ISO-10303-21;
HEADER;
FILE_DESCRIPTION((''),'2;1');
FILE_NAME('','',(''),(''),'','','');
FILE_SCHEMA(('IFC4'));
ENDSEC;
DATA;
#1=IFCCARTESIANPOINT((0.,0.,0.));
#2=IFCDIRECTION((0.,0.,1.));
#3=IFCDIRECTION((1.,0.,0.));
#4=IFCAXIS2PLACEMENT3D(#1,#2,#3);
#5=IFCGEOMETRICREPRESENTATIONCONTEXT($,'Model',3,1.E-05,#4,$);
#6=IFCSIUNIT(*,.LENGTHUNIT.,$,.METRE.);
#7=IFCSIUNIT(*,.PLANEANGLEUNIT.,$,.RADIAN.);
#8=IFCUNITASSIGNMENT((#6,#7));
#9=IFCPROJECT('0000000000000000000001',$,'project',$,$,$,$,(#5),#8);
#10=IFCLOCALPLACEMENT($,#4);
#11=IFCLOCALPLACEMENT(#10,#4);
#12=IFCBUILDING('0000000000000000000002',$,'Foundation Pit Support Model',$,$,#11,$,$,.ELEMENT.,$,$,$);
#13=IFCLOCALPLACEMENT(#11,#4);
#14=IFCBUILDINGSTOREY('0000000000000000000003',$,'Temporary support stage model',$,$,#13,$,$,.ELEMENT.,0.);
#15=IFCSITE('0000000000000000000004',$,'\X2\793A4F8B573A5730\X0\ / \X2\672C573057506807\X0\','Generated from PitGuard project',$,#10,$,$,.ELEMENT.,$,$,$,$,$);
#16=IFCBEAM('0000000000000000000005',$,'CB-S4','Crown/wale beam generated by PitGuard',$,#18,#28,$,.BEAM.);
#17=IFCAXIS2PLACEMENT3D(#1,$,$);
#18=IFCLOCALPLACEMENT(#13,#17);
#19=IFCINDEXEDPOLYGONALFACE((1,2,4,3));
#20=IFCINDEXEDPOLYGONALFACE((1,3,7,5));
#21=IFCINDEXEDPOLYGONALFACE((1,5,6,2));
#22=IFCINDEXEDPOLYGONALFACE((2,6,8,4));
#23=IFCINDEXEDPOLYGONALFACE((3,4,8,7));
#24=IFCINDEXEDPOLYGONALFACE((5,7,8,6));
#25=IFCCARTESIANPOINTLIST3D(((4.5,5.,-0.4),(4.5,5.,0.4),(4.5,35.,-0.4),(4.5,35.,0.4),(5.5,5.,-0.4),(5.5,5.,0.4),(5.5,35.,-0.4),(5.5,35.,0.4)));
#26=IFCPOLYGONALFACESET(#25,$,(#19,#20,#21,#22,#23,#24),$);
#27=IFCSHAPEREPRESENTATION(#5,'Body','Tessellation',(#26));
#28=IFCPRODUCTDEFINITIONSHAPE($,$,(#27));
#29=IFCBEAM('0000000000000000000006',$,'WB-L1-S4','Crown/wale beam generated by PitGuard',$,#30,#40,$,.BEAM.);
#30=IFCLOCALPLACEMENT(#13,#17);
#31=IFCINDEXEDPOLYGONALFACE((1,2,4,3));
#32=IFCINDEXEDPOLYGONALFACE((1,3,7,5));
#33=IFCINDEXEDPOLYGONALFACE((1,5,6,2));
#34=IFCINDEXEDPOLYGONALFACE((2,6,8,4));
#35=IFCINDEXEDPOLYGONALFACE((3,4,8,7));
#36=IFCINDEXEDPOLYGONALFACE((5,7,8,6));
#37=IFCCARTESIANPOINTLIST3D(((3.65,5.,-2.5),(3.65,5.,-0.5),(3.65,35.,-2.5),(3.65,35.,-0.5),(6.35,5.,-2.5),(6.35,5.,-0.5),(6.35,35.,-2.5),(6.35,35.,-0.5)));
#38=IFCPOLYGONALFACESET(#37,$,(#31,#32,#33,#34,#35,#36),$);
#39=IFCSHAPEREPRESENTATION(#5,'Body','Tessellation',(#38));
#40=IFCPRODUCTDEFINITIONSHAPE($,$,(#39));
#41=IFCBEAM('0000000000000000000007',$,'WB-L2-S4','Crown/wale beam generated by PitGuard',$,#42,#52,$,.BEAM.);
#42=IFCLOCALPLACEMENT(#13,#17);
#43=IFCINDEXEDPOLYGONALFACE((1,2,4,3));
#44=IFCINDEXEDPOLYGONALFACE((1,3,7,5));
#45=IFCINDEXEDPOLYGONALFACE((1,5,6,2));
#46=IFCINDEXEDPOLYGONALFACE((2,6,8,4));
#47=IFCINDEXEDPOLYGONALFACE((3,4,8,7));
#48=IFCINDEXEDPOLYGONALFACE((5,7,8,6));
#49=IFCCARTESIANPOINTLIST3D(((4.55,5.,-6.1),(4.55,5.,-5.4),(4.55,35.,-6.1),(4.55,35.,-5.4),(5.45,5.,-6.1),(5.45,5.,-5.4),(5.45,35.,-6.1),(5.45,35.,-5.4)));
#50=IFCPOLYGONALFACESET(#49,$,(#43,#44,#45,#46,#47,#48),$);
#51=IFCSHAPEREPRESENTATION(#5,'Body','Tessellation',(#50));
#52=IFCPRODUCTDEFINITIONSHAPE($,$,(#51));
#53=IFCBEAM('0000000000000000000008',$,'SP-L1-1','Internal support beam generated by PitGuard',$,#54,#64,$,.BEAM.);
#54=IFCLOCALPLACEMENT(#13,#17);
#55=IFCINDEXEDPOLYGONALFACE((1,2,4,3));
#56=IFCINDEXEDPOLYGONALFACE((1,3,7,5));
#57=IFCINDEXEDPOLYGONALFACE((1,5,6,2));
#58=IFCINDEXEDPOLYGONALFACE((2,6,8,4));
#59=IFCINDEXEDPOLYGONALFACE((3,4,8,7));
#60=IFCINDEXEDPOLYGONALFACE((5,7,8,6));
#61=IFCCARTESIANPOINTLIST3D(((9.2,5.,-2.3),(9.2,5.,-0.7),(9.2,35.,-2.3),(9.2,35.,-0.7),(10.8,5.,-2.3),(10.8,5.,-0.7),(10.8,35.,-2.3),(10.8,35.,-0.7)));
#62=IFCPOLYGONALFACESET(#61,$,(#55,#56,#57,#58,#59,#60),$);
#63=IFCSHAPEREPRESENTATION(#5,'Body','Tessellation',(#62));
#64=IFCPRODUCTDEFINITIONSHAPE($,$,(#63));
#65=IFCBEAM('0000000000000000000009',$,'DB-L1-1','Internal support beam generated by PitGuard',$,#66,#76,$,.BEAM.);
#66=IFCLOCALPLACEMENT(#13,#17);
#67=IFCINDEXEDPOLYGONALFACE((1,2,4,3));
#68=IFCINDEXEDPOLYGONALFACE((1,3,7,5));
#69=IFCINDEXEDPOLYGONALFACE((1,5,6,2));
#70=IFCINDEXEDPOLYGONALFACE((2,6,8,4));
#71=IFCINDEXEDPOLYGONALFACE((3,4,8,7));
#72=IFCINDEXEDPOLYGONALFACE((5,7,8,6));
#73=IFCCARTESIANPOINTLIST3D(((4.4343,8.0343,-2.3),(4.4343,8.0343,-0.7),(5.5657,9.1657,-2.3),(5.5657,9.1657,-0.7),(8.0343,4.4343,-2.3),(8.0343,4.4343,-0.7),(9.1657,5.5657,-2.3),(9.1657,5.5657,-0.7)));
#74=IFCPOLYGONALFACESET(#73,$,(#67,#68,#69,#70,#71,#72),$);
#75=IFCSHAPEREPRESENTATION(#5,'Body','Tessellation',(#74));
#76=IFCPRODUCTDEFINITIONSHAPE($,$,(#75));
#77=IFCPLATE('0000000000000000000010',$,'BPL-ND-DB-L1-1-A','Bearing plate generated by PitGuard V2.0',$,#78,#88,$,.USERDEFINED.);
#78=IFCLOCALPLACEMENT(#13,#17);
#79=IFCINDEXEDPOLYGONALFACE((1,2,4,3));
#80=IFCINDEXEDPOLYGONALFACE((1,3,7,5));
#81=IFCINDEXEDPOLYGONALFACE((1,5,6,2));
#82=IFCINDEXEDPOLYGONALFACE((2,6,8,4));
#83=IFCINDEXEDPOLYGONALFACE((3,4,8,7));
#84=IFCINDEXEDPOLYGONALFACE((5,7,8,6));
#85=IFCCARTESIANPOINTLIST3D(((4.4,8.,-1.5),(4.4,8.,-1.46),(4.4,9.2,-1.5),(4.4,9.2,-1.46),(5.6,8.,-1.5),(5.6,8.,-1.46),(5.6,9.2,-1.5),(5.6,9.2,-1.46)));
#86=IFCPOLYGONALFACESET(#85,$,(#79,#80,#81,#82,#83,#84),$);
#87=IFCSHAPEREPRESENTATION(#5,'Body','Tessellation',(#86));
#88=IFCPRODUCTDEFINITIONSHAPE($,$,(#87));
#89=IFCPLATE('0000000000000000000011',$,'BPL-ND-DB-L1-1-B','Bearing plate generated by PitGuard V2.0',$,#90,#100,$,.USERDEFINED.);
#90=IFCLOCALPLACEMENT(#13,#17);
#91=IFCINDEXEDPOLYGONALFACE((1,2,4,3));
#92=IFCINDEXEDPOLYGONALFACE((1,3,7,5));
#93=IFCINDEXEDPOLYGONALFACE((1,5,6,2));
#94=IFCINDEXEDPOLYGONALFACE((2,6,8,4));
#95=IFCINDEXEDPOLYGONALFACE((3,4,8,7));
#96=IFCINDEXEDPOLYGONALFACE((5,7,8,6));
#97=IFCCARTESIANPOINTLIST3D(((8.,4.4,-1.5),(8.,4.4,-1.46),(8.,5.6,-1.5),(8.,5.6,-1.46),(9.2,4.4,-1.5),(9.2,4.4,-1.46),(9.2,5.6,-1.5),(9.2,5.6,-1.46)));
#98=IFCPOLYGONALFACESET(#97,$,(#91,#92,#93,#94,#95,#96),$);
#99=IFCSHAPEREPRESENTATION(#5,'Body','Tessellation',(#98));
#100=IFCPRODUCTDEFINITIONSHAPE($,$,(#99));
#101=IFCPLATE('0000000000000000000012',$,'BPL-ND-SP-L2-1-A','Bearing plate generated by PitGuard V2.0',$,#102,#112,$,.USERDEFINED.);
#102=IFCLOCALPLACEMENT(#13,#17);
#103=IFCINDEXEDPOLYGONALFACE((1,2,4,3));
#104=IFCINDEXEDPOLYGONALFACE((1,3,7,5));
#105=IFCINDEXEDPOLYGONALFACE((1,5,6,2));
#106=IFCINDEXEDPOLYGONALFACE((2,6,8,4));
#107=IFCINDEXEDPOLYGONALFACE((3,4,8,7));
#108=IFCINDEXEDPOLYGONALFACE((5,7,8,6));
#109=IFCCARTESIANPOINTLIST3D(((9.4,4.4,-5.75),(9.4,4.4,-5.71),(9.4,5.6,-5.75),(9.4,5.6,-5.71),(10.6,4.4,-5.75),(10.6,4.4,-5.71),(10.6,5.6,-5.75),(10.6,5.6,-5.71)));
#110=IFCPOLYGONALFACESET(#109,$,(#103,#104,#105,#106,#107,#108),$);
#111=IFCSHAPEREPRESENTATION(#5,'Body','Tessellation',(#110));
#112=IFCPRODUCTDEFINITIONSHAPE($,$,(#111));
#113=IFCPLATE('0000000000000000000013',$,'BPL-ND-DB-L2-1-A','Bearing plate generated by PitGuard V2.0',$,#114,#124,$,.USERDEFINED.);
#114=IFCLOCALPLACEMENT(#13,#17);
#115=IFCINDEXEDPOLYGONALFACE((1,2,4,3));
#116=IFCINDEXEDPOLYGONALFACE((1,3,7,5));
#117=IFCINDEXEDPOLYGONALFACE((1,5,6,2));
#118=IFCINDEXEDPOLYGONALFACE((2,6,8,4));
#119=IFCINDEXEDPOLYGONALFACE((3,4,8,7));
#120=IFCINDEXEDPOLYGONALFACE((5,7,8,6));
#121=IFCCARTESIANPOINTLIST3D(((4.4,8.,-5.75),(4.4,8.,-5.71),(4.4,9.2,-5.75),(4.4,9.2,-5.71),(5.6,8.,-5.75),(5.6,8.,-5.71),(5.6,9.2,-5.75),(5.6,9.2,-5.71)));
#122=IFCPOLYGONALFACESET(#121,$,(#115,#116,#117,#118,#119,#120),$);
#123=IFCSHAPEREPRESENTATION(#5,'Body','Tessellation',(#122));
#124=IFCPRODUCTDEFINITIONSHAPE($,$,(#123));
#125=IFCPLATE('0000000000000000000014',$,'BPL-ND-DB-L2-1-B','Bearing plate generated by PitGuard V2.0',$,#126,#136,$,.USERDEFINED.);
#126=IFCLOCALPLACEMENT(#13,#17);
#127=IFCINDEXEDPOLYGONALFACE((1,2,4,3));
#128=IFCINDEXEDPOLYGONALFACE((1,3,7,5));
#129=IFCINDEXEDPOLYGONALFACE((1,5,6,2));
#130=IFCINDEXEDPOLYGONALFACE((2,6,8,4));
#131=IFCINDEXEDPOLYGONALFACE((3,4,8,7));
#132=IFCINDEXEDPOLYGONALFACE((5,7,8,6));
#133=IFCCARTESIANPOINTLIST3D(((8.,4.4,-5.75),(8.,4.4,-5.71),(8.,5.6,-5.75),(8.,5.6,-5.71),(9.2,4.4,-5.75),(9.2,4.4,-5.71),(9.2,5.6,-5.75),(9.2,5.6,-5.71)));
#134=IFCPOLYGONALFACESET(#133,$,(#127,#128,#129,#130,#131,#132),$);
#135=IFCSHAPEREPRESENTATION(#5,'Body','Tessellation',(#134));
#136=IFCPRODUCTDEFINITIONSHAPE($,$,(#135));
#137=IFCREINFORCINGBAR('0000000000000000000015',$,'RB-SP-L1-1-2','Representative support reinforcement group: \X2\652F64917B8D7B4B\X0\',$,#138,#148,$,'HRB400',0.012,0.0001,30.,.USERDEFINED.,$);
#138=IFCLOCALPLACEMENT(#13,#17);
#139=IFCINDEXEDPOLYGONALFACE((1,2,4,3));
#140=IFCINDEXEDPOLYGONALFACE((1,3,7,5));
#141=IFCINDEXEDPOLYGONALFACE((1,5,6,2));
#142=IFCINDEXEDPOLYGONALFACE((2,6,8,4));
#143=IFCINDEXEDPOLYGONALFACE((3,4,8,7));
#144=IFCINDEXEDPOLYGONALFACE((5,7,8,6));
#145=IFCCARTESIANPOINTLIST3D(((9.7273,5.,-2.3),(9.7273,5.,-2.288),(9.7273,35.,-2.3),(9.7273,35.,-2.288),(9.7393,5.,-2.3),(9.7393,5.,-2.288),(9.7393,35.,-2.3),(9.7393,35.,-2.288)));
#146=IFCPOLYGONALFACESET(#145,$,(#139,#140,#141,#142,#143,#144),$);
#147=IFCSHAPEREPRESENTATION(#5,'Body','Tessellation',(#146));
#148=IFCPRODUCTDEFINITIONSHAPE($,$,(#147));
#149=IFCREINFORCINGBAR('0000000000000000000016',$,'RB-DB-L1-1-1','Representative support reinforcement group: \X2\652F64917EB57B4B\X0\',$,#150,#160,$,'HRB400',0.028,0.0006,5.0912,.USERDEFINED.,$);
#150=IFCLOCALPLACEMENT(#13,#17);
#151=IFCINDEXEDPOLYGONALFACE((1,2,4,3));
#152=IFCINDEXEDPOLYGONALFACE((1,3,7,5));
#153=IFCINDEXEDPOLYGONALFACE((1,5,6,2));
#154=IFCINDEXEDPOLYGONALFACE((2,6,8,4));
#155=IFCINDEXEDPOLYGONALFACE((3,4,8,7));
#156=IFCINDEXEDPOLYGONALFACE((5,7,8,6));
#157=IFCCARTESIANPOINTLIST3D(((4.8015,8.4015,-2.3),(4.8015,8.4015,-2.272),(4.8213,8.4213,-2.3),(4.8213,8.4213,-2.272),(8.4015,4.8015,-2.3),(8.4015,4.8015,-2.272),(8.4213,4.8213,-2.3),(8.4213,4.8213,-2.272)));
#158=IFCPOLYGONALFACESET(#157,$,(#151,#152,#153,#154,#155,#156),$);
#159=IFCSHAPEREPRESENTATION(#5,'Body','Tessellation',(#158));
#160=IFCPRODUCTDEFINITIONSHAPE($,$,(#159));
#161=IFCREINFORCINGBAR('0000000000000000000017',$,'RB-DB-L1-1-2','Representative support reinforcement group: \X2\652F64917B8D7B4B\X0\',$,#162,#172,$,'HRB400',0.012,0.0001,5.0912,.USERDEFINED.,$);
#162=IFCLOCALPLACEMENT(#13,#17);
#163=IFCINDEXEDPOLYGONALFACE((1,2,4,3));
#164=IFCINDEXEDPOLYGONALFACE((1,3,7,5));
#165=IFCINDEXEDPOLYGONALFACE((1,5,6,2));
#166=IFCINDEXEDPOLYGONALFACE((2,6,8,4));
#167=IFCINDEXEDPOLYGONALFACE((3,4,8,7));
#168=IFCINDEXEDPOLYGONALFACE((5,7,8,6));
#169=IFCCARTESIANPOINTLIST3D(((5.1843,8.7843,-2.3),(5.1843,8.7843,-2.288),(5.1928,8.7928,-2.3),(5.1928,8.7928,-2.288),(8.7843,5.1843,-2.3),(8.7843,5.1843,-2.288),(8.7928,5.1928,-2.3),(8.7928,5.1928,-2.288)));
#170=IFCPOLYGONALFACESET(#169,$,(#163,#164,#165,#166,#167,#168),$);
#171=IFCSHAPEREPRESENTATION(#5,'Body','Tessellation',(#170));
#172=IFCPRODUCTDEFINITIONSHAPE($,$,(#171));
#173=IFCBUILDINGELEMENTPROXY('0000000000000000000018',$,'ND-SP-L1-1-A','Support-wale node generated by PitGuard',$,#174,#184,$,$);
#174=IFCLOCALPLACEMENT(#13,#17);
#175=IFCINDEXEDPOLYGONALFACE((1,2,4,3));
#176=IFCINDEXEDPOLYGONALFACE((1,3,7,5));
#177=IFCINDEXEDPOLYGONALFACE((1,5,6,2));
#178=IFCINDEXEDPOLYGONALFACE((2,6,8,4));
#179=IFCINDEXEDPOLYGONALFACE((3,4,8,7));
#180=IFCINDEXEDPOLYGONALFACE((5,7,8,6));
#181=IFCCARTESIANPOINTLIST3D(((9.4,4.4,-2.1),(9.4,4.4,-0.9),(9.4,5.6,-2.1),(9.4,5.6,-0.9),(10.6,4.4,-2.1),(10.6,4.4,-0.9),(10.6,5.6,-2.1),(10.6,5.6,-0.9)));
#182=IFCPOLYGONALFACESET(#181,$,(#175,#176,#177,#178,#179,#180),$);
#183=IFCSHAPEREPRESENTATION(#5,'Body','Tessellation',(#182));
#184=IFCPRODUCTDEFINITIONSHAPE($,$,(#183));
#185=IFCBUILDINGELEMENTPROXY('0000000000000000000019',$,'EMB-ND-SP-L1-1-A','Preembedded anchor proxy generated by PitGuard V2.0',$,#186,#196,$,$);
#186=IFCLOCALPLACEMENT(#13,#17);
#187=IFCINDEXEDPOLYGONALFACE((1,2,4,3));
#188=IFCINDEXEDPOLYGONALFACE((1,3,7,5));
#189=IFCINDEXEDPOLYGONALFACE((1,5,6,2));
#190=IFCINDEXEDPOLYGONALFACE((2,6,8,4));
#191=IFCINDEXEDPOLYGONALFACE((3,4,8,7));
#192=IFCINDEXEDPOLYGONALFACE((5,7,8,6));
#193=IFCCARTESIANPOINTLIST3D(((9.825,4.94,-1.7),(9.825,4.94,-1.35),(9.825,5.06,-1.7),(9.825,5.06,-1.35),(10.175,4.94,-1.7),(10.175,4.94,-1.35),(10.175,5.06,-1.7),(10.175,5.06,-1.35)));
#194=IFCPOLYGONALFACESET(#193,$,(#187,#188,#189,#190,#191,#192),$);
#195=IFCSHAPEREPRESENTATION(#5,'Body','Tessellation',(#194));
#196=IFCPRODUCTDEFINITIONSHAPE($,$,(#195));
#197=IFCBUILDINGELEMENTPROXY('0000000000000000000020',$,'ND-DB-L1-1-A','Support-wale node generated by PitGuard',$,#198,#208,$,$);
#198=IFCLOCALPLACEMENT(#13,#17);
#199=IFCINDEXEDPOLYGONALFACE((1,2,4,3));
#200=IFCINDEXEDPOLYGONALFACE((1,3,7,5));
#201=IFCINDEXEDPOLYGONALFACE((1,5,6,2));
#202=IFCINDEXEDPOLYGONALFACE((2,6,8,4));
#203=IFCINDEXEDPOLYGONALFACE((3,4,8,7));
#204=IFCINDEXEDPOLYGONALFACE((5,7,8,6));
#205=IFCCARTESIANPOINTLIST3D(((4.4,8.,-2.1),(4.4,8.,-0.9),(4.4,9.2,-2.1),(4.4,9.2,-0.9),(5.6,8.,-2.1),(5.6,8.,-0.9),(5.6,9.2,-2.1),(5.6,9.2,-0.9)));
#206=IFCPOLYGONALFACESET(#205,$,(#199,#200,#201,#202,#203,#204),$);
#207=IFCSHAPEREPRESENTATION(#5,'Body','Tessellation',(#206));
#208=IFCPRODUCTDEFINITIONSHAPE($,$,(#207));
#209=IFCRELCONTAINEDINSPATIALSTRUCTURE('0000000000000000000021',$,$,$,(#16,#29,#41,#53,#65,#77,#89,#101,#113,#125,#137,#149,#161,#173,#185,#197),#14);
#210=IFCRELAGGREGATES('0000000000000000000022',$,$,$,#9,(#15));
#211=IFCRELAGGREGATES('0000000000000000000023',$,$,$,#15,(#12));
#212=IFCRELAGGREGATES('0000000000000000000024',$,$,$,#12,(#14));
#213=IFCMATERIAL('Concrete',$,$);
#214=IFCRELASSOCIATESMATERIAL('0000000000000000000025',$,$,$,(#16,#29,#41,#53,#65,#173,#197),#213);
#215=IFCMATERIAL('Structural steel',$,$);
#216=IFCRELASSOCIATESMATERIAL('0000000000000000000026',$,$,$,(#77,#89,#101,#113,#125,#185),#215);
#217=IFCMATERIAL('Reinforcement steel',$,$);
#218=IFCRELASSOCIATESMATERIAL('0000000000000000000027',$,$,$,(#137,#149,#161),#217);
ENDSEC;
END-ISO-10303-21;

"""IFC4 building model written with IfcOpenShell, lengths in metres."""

from ifc_helpers import new_model, si_unit, frame, origin_with_axes, origin_2d, place, context, project, spatial, rectangle, extrude, material, element, save


model = new_model("IFC4")

# Units and contexts
model_context = context("Model", 3, precision=1e-05, world=origin_with_axes())
ifc_project = project(units=[si_unit("LENGTHUNIT", "METRE"), si_unit("PLANEANGLEUNIT", "RADIAN")], contexts=[model_context])

# Site, building, storey
site_placement = place(None, origin_with_axes())
site = spatial("IfcSite", under=ifc_project, at=site_placement, Name="示例场地 / 本地坐标", Description="Generated from PitGuard project", CompositionType="ELEMENT")
building_placement = place(site_placement, origin_with_axes())
building = spatial("IfcBuilding", under=site, at=building_placement, Name="Foundation Pit Support Model", CompositionType="ELEMENT")
storey_placement = place(building_placement, origin_with_axes())
storey = spatial("IfcBuildingStorey", under=building, at=storey_placement, Name="Temporary support stage model", CompositionType="ELEMENT", Elevation=0.0)

# Beams
ifc_material_1 = material(Name="Concrete")
beam_1_placement = place(storey_placement, frame((5.0, 20.0, -0.4), z_axis=(0.0, 0.0, 1.0), x_axis=(0.0, -1.0, 0.0)))
element("IfcBeam", 1, at=beam_1_placement, inside=storey, material=ifc_material_1, Name="CB-S4", Description="Crown/wale beam generated by PitGuard", PredefinedType="BEAM", context=model_context, shape_type="SweptSolid", body=[
    extrude(rectangle(XDim=30.0, YDim=1.0, at=origin_2d()), origin_with_axes(), (0.0, 0.0, 1.0), 0.8),
])
beam_2_placement = place(storey_placement, frame((5.0, 20.0, -2.5), z_axis=(0.0, 0.0, 1.0), x_axis=(0.0, -1.0, 0.0)))
element("IfcBeam", 2, at=beam_2_placement, inside=storey, material=ifc_material_1, Name="WB-L1-S4", Description="Crown/wale beam generated by PitGuard", PredefinedType="BEAM", context=model_context, shape_type="SweptSolid", body=[
    extrude(rectangle(XDim=30.0, YDim=2.7, at=origin_2d()), origin_with_axes(), (0.0, 0.0, 1.0), 2.0),
])
beam_3_placement = place(storey_placement, frame((5.0, 20.0, -6.1), z_axis=(0.0, 0.0, 1.0), x_axis=(0.0, -1.0, 0.0)))
element("IfcBeam", 3, at=beam_3_placement, inside=storey, material=ifc_material_1, Name="WB-L2-S4", Description="Crown/wale beam generated by PitGuard", PredefinedType="BEAM", context=model_context, shape_type="SweptSolid", body=[
    extrude(rectangle(XDim=30.0, YDim=0.9, at=origin_2d()), origin_with_axes(), (0.0, 0.0, 1.0), 0.7),
])
beam_4_placement = place(storey_placement, frame((10.0, 20.0, -2.3), z_axis=(0.0, 0.0, 1.0), x_axis=(0.0, 1.0, 0.0)))
element("IfcBeam", 4, at=beam_4_placement, inside=storey, material=ifc_material_1, Name="SP-L1-1", Description="Internal support beam generated by PitGuard", PredefinedType="BEAM", context=model_context, shape_type="SweptSolid", body=[
    extrude(rectangle(XDim=30.0, YDim=1.6, at=origin_2d()), origin_with_axes(), (0.0, 0.0, 1.0), 1.6),
])
beam_5_placement = place(storey_placement, frame((6.8, 6.8, -2.3), z_axis=(0.0, 0.0, 1.0), x_axis=(0.707107, -0.707107, 0.0)))
element("IfcBeam", 5, at=beam_5_placement, inside=storey, material=ifc_material_1, Name="DB-L1-1", Description="Internal support beam generated by PitGuard", PredefinedType="BEAM", context=model_context, shape_type="SweptSolid", body=[
    extrude(rectangle(XDim=5.0912, YDim=1.6, at=origin_2d()), origin_with_axes(), (0.0, 0.0, 1.0), 1.6),
])

# Plates
ifc_material_2 = material(Name="Structural steel")
for number, where, z_axis, x_axis, name in (
    (6, (5.0, 8.6, -1.5), (0.0, 0.0, 1.0), (1.0, 0.0, 0.0), "BPL-ND-DB-L1-1-A"),
    (7, (8.6, 5.0, -1.5), (0.0, 0.0, 1.0), (1.0, 0.0, 0.0), "BPL-ND-DB-L1-1-B"),
    (8, (10.0, 5.0, -5.75), (0.0, 0.0, 1.0), (1.0, 0.0, 0.0), "BPL-ND-SP-L2-1-A"),
    (9, (5.0, 8.6, -5.75), (0.0, 0.0, 1.0), (1.0, 0.0, 0.0), "BPL-ND-DB-L2-1-A"),
    (10, (8.6, 5.0, -5.75), (0.0, 0.0, 1.0), (1.0, 0.0, 0.0), "BPL-ND-DB-L2-1-B"),
):
    element("IfcPlate", number, at=place(storey_placement, frame(where, z_axis=z_axis, x_axis=x_axis)), inside=storey, material=ifc_material_2, Name=name, Description="Bearing plate generated by PitGuard V2.0", PredefinedType="USERDEFINED", context=model_context, shape_type="SweptSolid", body=[
        extrude(rectangle(XDim=1.2, YDim=1.2, at=origin_2d()), origin_with_axes(), (0.0, 0.0, 1.0), 0.04),
    ])

# Reinforcing bars
ifc_material_3 = material(Name="Reinforcement steel")
reinforcing_bar_1_placement = place(storey_placement, frame((9.7333, 20.0, -2.3), z_axis=(0.0, 0.0, 1.0), x_axis=(0.0, 1.0, 0.0)))
element("IfcReinforcingBar", 11, at=reinforcing_bar_1_placement, inside=storey, material=ifc_material_3, Name="RB-SP-L1-1-2", Description="Representative support reinforcement group: 支撑箍筋", SteelGrade="HRB400", BarLength=30.0, CrossSectionArea=0.0001, NominalDiameter=0.012, PredefinedType="USERDEFINED", context=model_context, shape_type="SweptSolid", body=[
    extrude(rectangle(XDim=30.0, YDim=0.012, at=origin_2d()), origin_with_axes(), (0.0, 0.0, 1.0), 0.012),
])
reinforcing_bar_2_placement = place(storey_placement, frame((6.6114, 6.6114, -2.3), z_axis=(0.0, 0.0, 1.0), x_axis=(0.707107, -0.707107, 0.0)))
element("IfcReinforcingBar", 12, at=reinforcing_bar_2_placement, inside=storey, material=ifc_material_3, Name="RB-DB-L1-1-1", Description="Representative support reinforcement group: 支撑纵筋", SteelGrade="HRB400", BarLength=5.0912, CrossSectionArea=0.0006, NominalDiameter=0.028, PredefinedType="USERDEFINED", context=model_context, shape_type="SweptSolid", body=[
    extrude(rectangle(XDim=5.0912, YDim=0.028, at=origin_2d()), origin_with_axes(), (0.0, 0.0, 1.0), 0.028),
])
reinforcing_bar_3_placement = place(storey_placement, frame((6.9886, 6.9886, -2.3), z_axis=(0.0, 0.0, 1.0), x_axis=(0.707107, -0.707107, 0.0)))
element("IfcReinforcingBar", 13, at=reinforcing_bar_3_placement, inside=storey, material=ifc_material_3, Name="RB-DB-L1-1-2", Description="Representative support reinforcement group: 支撑箍筋", SteelGrade="HRB400", BarLength=5.0912, CrossSectionArea=0.0001, NominalDiameter=0.012, PredefinedType="USERDEFINED", context=model_context, shape_type="SweptSolid", body=[
    extrude(rectangle(XDim=5.0912, YDim=0.012, at=origin_2d()), origin_with_axes(), (0.0, 0.0, 1.0), 0.012),
])

# Building element proxies
proxy_1_placement = place(storey_placement, frame((10.0, 5.0, -2.1), z_axis=(0.0, 0.0, 1.0), x_axis=(1.0, 0.0, 0.0)))
element("IfcBuildingElementProxy", 14, at=proxy_1_placement, inside=storey, material=ifc_material_1, Name="ND-SP-L1-1-A", Description="Support-wale node generated by PitGuard", context=model_context, shape_type="SweptSolid", body=[
    extrude(rectangle(XDim=1.2, YDim=1.2, at=origin_2d()), origin_with_axes(), (0.0, 0.0, 1.0), 1.2),
])
proxy_2_placement = place(storey_placement, frame((10.0, 5.0, -1.7), z_axis=(0.0, 0.0, 1.0), x_axis=(1.0, 0.0, 0.0)))
element("IfcBuildingElementProxy", 15, at=proxy_2_placement, inside=storey, material=ifc_material_2, Name="EMB-ND-SP-L1-1-A", Description="Preembedded anchor proxy generated by PitGuard V2.0", context=model_context, shape_type="SweptSolid", body=[
    extrude(rectangle(XDim=0.35, YDim=0.12, at=origin_2d()), origin_with_axes(), (0.0, 0.0, 1.0), 0.35),
])
proxy_3_placement = place(storey_placement, frame((5.0, 8.6, -2.1), z_axis=(0.0, 0.0, 1.0), x_axis=(1.0, 0.0, 0.0)))
element("IfcBuildingElementProxy", 16, at=proxy_3_placement, inside=storey, material=ifc_material_1, Name="ND-DB-L1-1-A", Description="Support-wale node generated by PitGuard", context=model_context, shape_type="SweptSolid", body=[
    extrude(rectangle(XDim=1.2, YDim=1.2, at=origin_2d()), origin_with_axes(), (0.0, 0.0, 1.0), 1.2),
])

save(model, "model.ifc")
